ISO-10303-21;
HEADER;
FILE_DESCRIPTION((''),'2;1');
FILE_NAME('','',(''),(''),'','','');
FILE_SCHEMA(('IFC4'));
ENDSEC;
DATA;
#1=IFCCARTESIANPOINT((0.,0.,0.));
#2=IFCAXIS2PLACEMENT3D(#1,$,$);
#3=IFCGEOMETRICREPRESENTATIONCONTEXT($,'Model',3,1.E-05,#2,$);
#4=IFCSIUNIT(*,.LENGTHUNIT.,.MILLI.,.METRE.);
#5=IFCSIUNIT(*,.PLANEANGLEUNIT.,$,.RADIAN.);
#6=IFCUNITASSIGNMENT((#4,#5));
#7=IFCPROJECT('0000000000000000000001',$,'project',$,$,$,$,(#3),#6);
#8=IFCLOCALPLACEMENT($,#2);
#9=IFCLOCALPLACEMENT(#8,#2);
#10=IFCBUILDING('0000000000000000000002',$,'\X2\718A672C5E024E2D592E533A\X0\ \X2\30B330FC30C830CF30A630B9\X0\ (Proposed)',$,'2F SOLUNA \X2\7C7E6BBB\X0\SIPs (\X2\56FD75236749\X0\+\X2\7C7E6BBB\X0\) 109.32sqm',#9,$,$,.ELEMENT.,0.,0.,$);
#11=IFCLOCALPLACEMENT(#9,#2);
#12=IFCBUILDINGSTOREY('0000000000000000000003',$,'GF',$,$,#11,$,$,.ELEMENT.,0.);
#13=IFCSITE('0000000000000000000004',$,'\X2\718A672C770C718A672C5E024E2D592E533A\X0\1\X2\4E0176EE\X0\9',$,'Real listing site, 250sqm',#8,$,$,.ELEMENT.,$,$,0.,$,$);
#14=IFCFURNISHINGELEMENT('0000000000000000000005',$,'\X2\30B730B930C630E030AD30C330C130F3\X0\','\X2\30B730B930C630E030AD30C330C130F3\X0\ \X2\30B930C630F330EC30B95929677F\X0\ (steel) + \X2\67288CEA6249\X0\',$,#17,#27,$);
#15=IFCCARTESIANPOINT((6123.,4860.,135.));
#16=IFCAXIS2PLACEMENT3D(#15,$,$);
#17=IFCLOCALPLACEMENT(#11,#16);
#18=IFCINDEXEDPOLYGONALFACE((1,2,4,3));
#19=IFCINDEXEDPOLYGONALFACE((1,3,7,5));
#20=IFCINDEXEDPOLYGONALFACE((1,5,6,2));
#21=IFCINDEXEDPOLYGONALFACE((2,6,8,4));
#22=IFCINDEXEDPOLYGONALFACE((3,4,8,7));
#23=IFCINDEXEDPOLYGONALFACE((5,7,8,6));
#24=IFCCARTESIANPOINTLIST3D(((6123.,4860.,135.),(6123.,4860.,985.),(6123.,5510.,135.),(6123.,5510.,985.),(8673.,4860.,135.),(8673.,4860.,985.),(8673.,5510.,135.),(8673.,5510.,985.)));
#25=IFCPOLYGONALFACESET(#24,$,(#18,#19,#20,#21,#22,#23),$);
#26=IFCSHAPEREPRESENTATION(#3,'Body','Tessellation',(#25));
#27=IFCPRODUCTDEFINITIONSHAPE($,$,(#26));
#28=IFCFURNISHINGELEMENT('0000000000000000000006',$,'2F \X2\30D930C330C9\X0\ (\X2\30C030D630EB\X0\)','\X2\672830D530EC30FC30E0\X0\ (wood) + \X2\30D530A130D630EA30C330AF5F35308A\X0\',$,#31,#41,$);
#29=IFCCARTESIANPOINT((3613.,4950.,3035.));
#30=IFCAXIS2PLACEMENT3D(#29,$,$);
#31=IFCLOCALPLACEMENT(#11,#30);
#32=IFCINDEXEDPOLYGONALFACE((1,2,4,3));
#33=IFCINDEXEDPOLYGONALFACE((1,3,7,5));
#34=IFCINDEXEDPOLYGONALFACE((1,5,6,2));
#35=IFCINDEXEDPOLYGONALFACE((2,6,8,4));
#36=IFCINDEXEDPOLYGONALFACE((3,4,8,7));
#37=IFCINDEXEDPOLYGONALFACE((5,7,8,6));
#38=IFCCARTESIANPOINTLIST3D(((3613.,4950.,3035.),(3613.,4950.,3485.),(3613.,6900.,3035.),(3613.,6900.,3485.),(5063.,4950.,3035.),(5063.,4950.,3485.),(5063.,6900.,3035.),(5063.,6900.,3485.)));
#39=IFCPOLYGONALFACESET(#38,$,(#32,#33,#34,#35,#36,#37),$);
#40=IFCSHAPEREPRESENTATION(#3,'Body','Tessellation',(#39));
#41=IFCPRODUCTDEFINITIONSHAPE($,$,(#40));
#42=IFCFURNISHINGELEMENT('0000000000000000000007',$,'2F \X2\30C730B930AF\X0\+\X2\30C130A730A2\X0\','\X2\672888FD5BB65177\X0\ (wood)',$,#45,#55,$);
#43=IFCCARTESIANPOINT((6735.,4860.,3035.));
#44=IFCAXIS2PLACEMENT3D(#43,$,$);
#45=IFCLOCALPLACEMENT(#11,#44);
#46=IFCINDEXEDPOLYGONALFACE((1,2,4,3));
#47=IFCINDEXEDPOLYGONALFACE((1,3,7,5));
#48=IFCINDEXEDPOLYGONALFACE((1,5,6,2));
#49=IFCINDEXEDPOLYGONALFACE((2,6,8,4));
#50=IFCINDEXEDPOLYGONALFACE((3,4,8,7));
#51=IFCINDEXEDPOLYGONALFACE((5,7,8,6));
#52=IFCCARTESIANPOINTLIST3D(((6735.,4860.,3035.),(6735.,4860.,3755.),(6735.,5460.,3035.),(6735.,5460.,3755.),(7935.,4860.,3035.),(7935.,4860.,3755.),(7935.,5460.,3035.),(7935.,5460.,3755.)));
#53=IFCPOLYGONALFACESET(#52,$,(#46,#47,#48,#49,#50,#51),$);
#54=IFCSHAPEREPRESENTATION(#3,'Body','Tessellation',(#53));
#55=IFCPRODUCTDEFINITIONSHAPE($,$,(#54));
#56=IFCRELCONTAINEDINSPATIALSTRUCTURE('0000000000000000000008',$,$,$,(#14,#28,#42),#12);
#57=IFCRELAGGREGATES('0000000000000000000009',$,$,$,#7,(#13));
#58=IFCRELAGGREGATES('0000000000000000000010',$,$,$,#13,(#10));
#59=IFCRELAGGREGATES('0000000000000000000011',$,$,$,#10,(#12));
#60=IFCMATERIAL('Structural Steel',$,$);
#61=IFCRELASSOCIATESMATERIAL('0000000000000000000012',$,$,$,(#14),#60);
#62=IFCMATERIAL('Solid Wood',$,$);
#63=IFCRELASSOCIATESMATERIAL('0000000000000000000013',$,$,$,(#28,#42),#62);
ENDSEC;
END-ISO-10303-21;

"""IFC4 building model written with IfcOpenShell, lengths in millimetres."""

from ifc_helpers import new_model, si_unit, frame, frame_2d, origin, place, context, project, spatial, rectangle, extrude, material, element, save


model = new_model("IFC4")

# Units and contexts
model_context = context("Model", 3, precision=1e-05, world=origin())
ifc_project = project(units=[si_unit("LENGTHUNIT", "METRE", prefix="MILLI"), si_unit("PLANEANGLEUNIT", "RADIAN")], contexts=[model_context])

# Site, building, storey
site_placement = place(None, origin())
site = spatial("IfcSite", under=ifc_project, at=site_placement, Name="熊本県熊本市中央区1丁目9", ObjectType="Real listing site, 250sqm", CompositionType="ELEMENT", RefElevation=0.0)
building_placement = place(site_placement, origin())
building = spatial("IfcBuilding", under=site, at=building_placement, Name="熊本市中央区 コートハウス (Proposed)", ObjectType="2F SOLUNA 籾殻SIPs (国産杉+籾殻) 109.32sqm", CompositionType="ELEMENT", ElevationOfRefHeight=0.0, ElevationOfTerrain=0.0)
storey_placement = place(building_placement, origin())
storey = spatial("IfcBuildingStorey", under=building, at=storey_placement, Name="GF", CompositionType="ELEMENT", Elevation=0.0)

# Shared definitions
ifc_material_1 = material(Name="Solid Wood")

# Furnishing elements
ifc_material_2 = material(Name="Structural Steel")
furnishing_1_placement = place(storey_placement, frame((6123.0, 4860.0, 135.0)))
element("IfcFurnishingElement", 1, at=furnishing_1_placement, inside=storey, material=ifc_material_2, Name="システムキッチン", Description="システムキッチン ステンレス天板 (steel) + 木質扉", context=model_context, shape_type="SweptSolid", body=[
    extrude(rectangle(XDim=2550.0, YDim=650.0, at=frame_2d((1275.0, 325.0))), frame((6123.0, 4860.0, 135.0)), (0.0, 0.0, 1.0), 850.0),
])
furnishing_2_placement = place(storey_placement, frame((3613.0, 4950.0, 3035.0)))
element("IfcFurnishingElement", 2, at=furnishing_2_placement, inside=storey, material=ifc_material_1, Name="2F ベッド (ダブル)", Description="木フレーム (wood) + ファブリック張り", context=model_context, shape_type="SweptSolid", body=[
    extrude(rectangle(XDim=1450.0, YDim=1950.0, at=frame_2d((725.0, 975.0))), frame((3613.0, 4950.0, 3035.0)), (0.0, 0.0, 1.0), 450.0),
])
furnishing_3_placement = place(storey_placement, frame((6735.0, 4860.0, 3035.0)))
element("IfcFurnishingElement", 3, at=furnishing_3_placement, inside=storey, material=ifc_material_1, Name="2F デスク+チェア", Description="木製家具 (wood)", context=model_context, shape_type="SweptSolid", body=[
    extrude(rectangle(XDim=1200.0, YDim=600.0, at=frame_2d((600.0, 300.0))), frame((6735.0, 4860.0, 3035.0)), (0.0, 0.0, 1.0), 720.0),
])

save(model, "model.ifc")
